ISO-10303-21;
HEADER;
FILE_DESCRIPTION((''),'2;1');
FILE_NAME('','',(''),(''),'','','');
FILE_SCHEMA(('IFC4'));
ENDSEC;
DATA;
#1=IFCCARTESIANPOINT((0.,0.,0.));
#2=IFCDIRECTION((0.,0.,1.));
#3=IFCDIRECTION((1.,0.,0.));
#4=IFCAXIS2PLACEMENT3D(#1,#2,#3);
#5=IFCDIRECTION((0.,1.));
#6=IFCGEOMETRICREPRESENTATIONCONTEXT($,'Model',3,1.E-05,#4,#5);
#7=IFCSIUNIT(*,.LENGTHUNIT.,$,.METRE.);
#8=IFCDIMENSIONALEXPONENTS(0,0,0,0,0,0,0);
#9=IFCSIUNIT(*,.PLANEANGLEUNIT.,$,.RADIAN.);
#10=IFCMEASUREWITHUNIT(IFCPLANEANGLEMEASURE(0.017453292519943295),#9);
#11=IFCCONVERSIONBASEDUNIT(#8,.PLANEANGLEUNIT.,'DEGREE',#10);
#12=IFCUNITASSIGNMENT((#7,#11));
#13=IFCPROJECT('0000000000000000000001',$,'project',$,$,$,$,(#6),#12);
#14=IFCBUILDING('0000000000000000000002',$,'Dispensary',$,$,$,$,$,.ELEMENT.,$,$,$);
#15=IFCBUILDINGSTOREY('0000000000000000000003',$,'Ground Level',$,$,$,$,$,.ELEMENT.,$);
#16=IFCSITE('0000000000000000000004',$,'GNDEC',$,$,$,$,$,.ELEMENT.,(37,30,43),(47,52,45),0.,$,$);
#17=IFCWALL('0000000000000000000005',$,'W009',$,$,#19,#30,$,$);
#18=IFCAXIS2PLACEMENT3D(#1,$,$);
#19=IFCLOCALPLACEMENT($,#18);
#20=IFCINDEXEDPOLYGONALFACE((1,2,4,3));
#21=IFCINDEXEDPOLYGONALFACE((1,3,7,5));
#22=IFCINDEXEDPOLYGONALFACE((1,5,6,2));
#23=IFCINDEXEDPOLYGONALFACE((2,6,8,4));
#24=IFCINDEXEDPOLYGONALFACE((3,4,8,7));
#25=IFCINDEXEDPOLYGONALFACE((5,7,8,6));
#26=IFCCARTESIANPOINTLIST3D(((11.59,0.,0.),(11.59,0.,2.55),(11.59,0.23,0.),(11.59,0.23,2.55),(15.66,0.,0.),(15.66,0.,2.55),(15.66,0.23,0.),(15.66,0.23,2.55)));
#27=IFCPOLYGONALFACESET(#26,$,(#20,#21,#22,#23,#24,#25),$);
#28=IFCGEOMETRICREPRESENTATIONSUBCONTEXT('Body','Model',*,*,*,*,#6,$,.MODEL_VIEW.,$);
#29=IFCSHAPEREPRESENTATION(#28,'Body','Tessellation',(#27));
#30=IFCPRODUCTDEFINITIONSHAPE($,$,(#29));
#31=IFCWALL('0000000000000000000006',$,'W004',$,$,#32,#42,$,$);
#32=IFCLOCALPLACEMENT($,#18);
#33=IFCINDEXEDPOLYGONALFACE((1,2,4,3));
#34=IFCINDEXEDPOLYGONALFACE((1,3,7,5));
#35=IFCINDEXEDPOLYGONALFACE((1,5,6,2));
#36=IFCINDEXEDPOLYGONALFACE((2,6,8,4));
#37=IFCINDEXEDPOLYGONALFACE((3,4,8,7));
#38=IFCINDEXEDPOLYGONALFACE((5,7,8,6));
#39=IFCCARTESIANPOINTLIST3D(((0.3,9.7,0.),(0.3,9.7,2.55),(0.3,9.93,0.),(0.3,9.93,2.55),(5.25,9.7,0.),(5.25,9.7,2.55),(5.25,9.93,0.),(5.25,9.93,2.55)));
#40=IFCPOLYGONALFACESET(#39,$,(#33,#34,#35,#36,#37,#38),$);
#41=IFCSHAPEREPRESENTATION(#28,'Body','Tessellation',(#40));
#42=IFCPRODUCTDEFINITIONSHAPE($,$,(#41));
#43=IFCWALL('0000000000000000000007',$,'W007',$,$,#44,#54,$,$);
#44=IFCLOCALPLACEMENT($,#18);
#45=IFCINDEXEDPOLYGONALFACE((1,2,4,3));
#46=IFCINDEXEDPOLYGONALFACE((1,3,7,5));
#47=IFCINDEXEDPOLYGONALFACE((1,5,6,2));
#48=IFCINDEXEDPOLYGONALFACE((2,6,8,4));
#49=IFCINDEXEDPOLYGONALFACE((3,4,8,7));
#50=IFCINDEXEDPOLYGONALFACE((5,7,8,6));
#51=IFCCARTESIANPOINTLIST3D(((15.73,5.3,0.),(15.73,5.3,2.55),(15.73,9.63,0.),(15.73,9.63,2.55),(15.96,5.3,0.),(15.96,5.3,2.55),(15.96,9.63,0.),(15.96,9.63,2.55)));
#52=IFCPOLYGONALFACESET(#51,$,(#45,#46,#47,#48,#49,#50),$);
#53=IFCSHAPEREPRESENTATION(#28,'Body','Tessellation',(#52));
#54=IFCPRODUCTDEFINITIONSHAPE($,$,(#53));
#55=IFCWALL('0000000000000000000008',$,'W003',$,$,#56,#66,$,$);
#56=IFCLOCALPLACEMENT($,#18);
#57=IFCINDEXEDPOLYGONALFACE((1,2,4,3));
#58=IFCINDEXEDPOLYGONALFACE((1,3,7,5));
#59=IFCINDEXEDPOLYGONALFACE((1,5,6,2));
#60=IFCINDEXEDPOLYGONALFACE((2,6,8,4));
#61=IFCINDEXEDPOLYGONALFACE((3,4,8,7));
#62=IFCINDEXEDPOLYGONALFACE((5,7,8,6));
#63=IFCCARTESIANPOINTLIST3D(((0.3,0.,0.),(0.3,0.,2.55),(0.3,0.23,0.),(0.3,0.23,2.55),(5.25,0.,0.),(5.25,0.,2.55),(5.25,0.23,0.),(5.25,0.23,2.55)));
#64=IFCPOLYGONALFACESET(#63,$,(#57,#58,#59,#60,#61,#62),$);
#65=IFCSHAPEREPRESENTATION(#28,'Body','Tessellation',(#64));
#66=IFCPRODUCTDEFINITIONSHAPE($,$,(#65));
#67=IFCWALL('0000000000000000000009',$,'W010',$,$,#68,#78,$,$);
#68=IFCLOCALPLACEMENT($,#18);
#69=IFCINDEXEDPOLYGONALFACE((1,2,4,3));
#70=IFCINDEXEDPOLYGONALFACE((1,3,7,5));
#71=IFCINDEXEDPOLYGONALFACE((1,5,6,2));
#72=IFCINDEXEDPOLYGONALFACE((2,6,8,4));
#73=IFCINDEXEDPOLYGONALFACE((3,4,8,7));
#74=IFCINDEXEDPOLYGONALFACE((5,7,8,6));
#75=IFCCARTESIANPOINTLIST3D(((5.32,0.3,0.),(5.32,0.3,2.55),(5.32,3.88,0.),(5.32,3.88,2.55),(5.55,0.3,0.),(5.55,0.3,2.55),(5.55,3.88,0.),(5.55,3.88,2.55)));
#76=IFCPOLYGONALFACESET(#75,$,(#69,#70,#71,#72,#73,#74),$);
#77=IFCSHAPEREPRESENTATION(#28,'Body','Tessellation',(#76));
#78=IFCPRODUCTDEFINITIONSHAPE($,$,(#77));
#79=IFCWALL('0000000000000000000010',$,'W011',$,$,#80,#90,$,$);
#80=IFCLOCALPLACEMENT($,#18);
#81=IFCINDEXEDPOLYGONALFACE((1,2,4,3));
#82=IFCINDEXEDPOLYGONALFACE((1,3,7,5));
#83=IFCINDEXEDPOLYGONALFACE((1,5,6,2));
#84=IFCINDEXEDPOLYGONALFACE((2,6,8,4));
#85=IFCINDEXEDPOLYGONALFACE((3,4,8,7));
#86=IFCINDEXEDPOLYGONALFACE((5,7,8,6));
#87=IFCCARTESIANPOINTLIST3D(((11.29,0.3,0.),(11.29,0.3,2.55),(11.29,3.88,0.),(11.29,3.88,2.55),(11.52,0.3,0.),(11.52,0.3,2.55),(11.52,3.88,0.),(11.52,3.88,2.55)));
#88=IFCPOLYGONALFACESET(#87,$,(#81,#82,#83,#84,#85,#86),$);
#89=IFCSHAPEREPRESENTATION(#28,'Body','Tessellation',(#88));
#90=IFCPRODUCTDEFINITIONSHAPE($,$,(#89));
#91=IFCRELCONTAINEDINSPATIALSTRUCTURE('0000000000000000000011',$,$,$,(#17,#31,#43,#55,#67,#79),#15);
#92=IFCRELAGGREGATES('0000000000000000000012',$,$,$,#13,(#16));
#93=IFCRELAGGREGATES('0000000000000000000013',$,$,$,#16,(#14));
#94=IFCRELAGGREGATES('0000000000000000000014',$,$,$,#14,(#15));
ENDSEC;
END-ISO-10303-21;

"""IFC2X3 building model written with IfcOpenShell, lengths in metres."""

from ifc_helpers import new_model, entity, si_unit, converted_unit, direction, frame, frame_2d, origin_with_axes, place, context, subcontext, project, spatial, rectangle, extrude, element, save


model = new_model("IFC2X3")

# Units and contexts
model_context = context("Model", 3, precision=1e-05, world=origin_with_axes(), true_north=direction((0.0, 1.0)))
body_context = subcontext(model_context, "Body", "Model", "MODEL_VIEW")
ifc_project = project(units=[si_unit("LENGTHUNIT", "METRE"), converted_unit("PLANEANGLEUNIT", "DEGREE", entity("IfcPlaneAngleMeasure", 0.017453292519943295), si_unit("PLANEANGLEUNIT", "RADIAN"), dimensions=[0, 0, 0, 0, 0, 0, 0])], contexts=[model_context])

# Site, building, storey
site = spatial("IfcSite", under=ifc_project, Name="GNDEC", CompositionType="ELEMENT", RefLatitude=(37, 30, 43), RefLongitude=(47, 52, 45), RefElevation=0.0)
building = spatial("IfcBuilding", under=site, Name="Dispensary", CompositionType="ELEMENT")
storey = spatial("IfcBuildingStorey", under=building, Name="Ground Level", CompositionType="ELEMENT")

# Shared definitions
placement = place(None, origin_with_axes())

# Walls
element("IfcWall", 1, at=placement, inside=storey, Name="W009", context=body_context, shape_type="SweptSolid", body=[
    extrude(rectangle(XDim=4.07, YDim=0.23, at=frame_2d((0.0, 0.0), x_axis=(1.0, 0.0))), frame((13.625, 0.115, 0.0), z_axis=(0.0, 0.0, 1.0), x_axis=(1.0, 0.0, 0.0)), (0.0, 0.0, 1.0), 2.55),
])
element("IfcWall", 2, at=placement, inside=storey, Name="W004", context=body_context, shape_type="SweptSolid", body=[
    extrude(rectangle(XDim=4.95, YDim=0.23, at=frame_2d((0.0, 0.0), x_axis=(-1.0, 0.0))), frame((2.775, 9.815, 0.0), z_axis=(0.0, 0.0, 1.0), x_axis=(1.0, 0.0, 0.0)), (0.0, 0.0, 1.0), 2.55),
])
element("IfcWall", 3, at=placement, inside=storey, Name="W007", context=body_context, shape_type="SweptSolid", body=[
    extrude(rectangle(XDim=4.33, YDim=0.23, at=frame_2d((0.0, 0.0), x_axis=(0.0, 1.0))), frame((15.845, 7.465, 0.0), z_axis=(0.0, 0.0, 1.0), x_axis=(1.0, 0.0, 0.0)), (0.0, 0.0, 1.0), 2.55),
])
element("IfcWall", 4, at=placement, inside=storey, Name="W003", context=body_context, shape_type="SweptSolid", body=[
    extrude(rectangle(XDim=4.95, YDim=0.23, at=frame_2d((0.0, 0.0), x_axis=(1.0, 0.0))), frame((2.775, 0.115, 0.0), z_axis=(0.0, 0.0, 1.0), x_axis=(1.0, 0.0, 0.0)), (0.0, 0.0, 1.0), 2.55),
])
element("IfcWall", 5, at=placement, inside=storey, Name="W010", context=body_context, shape_type="SweptSolid", body=[
    extrude(rectangle(XDim=3.58, YDim=0.23, at=frame_2d((0.0, 0.0), x_axis=(0.0, 1.0))), frame((5.435, 2.09, 0.0), z_axis=(0.0, 0.0, 1.0), x_axis=(1.0, 0.0, 0.0)), (0.0, 0.0, 1.0), 2.55),
])
element("IfcWall", 6, at=placement, inside=storey, Name="W011", context=body_context, shape_type="SweptSolid", body=[
    extrude(rectangle(XDim=3.58, YDim=0.23, at=frame_2d((0.0, 0.0), x_axis=(0.0, -1.0))), frame((11.405, 2.09, 0.0), z_axis=(0.0, 0.0, 1.0), x_axis=(1.0, 0.0, 0.0)), (0.0, 0.0, 1.0), 2.55),
])

save(model, "model.ifc")
